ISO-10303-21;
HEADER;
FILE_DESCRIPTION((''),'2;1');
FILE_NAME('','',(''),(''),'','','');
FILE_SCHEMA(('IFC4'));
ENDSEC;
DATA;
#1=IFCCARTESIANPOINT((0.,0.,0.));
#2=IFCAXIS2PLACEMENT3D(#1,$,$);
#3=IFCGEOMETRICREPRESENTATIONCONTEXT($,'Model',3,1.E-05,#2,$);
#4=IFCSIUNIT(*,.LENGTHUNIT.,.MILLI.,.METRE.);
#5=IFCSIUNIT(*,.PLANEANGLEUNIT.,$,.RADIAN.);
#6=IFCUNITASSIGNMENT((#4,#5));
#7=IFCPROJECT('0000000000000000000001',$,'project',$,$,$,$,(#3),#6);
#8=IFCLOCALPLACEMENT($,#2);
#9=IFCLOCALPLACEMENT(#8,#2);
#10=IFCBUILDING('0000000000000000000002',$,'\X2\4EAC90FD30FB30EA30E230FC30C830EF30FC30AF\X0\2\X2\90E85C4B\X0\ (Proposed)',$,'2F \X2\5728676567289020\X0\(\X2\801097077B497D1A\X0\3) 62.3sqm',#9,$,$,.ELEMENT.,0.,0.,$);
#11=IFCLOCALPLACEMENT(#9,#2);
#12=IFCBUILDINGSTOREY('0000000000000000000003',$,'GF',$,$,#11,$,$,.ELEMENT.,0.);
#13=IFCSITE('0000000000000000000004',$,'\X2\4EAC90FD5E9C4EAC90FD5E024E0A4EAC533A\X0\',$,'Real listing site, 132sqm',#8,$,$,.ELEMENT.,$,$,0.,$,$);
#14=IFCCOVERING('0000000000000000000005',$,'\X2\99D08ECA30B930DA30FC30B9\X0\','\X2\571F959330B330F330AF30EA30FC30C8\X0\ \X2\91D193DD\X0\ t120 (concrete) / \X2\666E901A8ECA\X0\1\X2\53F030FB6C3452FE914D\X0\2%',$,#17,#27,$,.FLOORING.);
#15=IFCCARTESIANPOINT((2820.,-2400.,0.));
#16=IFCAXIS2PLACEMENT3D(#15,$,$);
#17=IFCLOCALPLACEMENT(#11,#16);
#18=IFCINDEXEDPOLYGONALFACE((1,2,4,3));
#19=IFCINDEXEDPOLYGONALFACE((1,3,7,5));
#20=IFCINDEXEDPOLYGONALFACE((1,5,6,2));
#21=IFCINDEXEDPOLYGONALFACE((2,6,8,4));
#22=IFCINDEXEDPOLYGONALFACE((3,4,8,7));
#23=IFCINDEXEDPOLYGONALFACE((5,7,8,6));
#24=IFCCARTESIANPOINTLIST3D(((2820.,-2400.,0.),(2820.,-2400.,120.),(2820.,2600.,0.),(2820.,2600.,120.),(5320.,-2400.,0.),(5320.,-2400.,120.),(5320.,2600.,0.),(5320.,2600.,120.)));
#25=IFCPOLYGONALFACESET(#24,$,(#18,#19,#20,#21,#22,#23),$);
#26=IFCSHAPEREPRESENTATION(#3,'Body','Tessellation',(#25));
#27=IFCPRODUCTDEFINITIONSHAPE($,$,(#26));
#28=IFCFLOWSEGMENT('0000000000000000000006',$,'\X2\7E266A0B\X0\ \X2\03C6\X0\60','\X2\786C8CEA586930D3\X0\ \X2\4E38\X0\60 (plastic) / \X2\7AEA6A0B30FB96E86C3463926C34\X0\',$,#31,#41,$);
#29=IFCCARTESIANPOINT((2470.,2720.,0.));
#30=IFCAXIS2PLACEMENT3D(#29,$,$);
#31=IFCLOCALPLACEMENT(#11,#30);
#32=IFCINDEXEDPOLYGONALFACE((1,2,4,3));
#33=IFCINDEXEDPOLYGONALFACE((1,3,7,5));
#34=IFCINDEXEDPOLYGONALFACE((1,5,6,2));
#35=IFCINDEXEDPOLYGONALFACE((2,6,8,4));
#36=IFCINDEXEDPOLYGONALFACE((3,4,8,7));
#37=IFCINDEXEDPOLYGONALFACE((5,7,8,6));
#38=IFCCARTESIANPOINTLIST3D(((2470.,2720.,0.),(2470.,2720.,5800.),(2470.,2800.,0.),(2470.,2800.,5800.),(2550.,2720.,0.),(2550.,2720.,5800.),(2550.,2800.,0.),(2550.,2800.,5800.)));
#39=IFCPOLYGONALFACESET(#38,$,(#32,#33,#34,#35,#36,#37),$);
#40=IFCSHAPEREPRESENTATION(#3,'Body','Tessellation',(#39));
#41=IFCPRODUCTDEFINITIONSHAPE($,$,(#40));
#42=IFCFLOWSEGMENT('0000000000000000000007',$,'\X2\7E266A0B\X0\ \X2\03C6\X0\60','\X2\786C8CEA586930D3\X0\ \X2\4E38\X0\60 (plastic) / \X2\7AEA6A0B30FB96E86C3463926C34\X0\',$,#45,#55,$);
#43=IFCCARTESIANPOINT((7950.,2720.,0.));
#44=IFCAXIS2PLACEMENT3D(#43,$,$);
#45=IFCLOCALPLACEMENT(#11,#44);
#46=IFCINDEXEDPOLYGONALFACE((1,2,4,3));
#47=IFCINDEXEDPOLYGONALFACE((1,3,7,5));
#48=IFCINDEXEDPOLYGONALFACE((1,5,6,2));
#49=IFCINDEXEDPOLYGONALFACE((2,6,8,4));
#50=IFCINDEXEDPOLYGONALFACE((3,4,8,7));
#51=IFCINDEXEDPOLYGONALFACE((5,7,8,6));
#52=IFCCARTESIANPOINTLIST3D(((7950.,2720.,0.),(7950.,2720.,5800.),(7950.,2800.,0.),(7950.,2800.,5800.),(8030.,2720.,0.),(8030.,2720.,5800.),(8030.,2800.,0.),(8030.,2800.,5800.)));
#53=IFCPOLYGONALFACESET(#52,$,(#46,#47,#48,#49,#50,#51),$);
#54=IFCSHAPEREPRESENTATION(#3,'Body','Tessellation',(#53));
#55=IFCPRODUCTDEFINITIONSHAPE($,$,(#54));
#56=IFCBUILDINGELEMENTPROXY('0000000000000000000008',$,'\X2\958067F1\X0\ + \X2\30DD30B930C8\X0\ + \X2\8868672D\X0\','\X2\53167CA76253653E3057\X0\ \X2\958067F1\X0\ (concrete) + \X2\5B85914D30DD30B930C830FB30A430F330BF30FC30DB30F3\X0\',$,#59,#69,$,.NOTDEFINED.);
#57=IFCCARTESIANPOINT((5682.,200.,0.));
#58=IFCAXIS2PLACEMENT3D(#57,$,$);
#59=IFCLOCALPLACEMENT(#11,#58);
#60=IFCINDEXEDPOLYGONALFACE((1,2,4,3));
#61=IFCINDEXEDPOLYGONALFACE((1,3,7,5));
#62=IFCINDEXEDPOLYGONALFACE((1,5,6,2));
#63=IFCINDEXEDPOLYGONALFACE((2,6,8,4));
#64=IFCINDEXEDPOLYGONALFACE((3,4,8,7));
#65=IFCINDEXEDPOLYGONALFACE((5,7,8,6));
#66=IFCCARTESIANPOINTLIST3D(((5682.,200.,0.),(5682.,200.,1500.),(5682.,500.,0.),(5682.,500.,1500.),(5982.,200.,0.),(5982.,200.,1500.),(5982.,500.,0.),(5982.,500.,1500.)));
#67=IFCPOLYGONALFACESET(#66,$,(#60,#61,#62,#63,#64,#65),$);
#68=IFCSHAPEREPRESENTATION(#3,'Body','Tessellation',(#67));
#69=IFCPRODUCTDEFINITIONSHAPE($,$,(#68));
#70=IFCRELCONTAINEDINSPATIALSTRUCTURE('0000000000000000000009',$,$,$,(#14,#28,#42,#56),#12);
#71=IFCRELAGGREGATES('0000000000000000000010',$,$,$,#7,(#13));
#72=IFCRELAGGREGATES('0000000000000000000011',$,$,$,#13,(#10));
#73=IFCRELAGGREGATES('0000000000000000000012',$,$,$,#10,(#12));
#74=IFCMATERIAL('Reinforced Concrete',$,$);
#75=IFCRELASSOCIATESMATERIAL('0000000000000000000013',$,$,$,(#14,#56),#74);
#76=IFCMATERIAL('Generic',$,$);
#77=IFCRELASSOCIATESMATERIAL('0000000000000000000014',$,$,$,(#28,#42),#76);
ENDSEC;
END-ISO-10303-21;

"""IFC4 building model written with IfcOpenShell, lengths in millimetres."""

from ifc_helpers import new_model, si_unit, frame, frame_2d, origin, place, context, project, spatial, rectangle, extrude, material, element, save


model = new_model("IFC4")

# Units and contexts
model_context = context("Model", 3, precision=1e-05, world=origin())
ifc_project = project(units=[si_unit("LENGTHUNIT", "METRE", prefix="MILLI"), si_unit("PLANEANGLEUNIT", "RADIAN")], contexts=[model_context])

# Site, building, storey
site_placement = place(None, origin())
site = spatial("IfcSite", under=ifc_project, at=site_placement, Name="京都府京都市上京区", ObjectType="Real listing site, 132sqm", CompositionType="ELEMENT", RefElevation=0.0)
building_placement = place(site_placement, origin())
building = spatial("IfcBuilding", under=site, at=building_placement, Name="京都・リモートワーク2部屋 (Proposed)", ObjectType="2F 在来木造(耐震等級3) 62.3sqm", CompositionType="ELEMENT", ElevationOfRefHeight=0.0, ElevationOfTerrain=0.0)
storey_placement = place(building_placement, origin())
storey = spatial("IfcBuildingStorey", under=building, at=storey_placement, Name="GF", CompositionType="ELEMENT", Elevation=0.0)

# Shared definitions
ifc_material_1 = material(Name="Reinforced Concrete")

# Covering
covering_1_placement = place(storey_placement, frame((2820.0, -2400.0, 0.0)))
element("IfcCovering", 1, at=covering_1_placement, inside=storey, material=ifc_material_1, Name="駐車スペース", Description="土間コンクリート 金鏝 t120 (concrete) / 普通車1台・水勾配2%", PredefinedType="FLOORING", context=model_context, shape_type="SweptSolid", body=[
    extrude(rectangle(XDim=2500.0, YDim=5000.0, at=frame_2d((1250.0, 2500.0))), frame((2820.0, -2400.0, 0.0)), (0.0, 0.0, 1.0), 120.0),
])

# Flow segments
ifc_material_2 = material(Name="Generic")
flow_segment_1_placement = place(storey_placement, frame((2470.0, 2720.0, 0.0)))
element("IfcFlowSegment", 2, at=flow_segment_1_placement, inside=storey, material=ifc_material_2, Name="縦樋 φ60", Description="硬質塩ビ 丸60 (plastic) / 竪樋・雨水排水", context=model_context, shape_type="SweptSolid", body=[
    extrude(rectangle(XDim=80.0, YDim=80.0, at=frame_2d((40.0, 40.0))), frame((2470.0, 2720.0, 0.0)), (0.0, 0.0, 1.0), 5800.0),
])
flow_segment_2_placement = place(storey_placement, frame((7950.0, 2720.0, 0.0)))
element("IfcFlowSegment", 3, at=flow_segment_2_placement, inside=storey, material=ifc_material_2, Name="縦樋 φ60", Description="硬質塩ビ 丸60 (plastic) / 竪樋・雨水排水", context=model_context, shape_type="SweptSolid", body=[
    extrude(rectangle(XDim=80.0, YDim=80.0, at=frame_2d((40.0, 40.0))), frame((7950.0, 2720.0, 0.0)), (0.0, 0.0, 1.0), 5800.0),
])

# Building element proxy
proxy_placement = place(storey_placement, frame((5682.0, 200.0, 0.0)))
element("IfcBuildingElementProxy", 4, at=proxy_placement, inside=storey, material=ifc_material_1, Name="門柱 + ポスト + 表札", Description="化粧打放し 門柱 (concrete) + 宅配ポスト・インターホン", PredefinedType="NOTDEFINED", context=model_context, shape_type="SweptSolid", body=[
    extrude(rectangle(XDim=300.0, YDim=300.0, at=frame_2d((150.0, 150.0))), frame((5682.0, 200.0, 0.0)), (0.0, 0.0, 1.0), 1500.0),
])

save(model, "model.ifc")
